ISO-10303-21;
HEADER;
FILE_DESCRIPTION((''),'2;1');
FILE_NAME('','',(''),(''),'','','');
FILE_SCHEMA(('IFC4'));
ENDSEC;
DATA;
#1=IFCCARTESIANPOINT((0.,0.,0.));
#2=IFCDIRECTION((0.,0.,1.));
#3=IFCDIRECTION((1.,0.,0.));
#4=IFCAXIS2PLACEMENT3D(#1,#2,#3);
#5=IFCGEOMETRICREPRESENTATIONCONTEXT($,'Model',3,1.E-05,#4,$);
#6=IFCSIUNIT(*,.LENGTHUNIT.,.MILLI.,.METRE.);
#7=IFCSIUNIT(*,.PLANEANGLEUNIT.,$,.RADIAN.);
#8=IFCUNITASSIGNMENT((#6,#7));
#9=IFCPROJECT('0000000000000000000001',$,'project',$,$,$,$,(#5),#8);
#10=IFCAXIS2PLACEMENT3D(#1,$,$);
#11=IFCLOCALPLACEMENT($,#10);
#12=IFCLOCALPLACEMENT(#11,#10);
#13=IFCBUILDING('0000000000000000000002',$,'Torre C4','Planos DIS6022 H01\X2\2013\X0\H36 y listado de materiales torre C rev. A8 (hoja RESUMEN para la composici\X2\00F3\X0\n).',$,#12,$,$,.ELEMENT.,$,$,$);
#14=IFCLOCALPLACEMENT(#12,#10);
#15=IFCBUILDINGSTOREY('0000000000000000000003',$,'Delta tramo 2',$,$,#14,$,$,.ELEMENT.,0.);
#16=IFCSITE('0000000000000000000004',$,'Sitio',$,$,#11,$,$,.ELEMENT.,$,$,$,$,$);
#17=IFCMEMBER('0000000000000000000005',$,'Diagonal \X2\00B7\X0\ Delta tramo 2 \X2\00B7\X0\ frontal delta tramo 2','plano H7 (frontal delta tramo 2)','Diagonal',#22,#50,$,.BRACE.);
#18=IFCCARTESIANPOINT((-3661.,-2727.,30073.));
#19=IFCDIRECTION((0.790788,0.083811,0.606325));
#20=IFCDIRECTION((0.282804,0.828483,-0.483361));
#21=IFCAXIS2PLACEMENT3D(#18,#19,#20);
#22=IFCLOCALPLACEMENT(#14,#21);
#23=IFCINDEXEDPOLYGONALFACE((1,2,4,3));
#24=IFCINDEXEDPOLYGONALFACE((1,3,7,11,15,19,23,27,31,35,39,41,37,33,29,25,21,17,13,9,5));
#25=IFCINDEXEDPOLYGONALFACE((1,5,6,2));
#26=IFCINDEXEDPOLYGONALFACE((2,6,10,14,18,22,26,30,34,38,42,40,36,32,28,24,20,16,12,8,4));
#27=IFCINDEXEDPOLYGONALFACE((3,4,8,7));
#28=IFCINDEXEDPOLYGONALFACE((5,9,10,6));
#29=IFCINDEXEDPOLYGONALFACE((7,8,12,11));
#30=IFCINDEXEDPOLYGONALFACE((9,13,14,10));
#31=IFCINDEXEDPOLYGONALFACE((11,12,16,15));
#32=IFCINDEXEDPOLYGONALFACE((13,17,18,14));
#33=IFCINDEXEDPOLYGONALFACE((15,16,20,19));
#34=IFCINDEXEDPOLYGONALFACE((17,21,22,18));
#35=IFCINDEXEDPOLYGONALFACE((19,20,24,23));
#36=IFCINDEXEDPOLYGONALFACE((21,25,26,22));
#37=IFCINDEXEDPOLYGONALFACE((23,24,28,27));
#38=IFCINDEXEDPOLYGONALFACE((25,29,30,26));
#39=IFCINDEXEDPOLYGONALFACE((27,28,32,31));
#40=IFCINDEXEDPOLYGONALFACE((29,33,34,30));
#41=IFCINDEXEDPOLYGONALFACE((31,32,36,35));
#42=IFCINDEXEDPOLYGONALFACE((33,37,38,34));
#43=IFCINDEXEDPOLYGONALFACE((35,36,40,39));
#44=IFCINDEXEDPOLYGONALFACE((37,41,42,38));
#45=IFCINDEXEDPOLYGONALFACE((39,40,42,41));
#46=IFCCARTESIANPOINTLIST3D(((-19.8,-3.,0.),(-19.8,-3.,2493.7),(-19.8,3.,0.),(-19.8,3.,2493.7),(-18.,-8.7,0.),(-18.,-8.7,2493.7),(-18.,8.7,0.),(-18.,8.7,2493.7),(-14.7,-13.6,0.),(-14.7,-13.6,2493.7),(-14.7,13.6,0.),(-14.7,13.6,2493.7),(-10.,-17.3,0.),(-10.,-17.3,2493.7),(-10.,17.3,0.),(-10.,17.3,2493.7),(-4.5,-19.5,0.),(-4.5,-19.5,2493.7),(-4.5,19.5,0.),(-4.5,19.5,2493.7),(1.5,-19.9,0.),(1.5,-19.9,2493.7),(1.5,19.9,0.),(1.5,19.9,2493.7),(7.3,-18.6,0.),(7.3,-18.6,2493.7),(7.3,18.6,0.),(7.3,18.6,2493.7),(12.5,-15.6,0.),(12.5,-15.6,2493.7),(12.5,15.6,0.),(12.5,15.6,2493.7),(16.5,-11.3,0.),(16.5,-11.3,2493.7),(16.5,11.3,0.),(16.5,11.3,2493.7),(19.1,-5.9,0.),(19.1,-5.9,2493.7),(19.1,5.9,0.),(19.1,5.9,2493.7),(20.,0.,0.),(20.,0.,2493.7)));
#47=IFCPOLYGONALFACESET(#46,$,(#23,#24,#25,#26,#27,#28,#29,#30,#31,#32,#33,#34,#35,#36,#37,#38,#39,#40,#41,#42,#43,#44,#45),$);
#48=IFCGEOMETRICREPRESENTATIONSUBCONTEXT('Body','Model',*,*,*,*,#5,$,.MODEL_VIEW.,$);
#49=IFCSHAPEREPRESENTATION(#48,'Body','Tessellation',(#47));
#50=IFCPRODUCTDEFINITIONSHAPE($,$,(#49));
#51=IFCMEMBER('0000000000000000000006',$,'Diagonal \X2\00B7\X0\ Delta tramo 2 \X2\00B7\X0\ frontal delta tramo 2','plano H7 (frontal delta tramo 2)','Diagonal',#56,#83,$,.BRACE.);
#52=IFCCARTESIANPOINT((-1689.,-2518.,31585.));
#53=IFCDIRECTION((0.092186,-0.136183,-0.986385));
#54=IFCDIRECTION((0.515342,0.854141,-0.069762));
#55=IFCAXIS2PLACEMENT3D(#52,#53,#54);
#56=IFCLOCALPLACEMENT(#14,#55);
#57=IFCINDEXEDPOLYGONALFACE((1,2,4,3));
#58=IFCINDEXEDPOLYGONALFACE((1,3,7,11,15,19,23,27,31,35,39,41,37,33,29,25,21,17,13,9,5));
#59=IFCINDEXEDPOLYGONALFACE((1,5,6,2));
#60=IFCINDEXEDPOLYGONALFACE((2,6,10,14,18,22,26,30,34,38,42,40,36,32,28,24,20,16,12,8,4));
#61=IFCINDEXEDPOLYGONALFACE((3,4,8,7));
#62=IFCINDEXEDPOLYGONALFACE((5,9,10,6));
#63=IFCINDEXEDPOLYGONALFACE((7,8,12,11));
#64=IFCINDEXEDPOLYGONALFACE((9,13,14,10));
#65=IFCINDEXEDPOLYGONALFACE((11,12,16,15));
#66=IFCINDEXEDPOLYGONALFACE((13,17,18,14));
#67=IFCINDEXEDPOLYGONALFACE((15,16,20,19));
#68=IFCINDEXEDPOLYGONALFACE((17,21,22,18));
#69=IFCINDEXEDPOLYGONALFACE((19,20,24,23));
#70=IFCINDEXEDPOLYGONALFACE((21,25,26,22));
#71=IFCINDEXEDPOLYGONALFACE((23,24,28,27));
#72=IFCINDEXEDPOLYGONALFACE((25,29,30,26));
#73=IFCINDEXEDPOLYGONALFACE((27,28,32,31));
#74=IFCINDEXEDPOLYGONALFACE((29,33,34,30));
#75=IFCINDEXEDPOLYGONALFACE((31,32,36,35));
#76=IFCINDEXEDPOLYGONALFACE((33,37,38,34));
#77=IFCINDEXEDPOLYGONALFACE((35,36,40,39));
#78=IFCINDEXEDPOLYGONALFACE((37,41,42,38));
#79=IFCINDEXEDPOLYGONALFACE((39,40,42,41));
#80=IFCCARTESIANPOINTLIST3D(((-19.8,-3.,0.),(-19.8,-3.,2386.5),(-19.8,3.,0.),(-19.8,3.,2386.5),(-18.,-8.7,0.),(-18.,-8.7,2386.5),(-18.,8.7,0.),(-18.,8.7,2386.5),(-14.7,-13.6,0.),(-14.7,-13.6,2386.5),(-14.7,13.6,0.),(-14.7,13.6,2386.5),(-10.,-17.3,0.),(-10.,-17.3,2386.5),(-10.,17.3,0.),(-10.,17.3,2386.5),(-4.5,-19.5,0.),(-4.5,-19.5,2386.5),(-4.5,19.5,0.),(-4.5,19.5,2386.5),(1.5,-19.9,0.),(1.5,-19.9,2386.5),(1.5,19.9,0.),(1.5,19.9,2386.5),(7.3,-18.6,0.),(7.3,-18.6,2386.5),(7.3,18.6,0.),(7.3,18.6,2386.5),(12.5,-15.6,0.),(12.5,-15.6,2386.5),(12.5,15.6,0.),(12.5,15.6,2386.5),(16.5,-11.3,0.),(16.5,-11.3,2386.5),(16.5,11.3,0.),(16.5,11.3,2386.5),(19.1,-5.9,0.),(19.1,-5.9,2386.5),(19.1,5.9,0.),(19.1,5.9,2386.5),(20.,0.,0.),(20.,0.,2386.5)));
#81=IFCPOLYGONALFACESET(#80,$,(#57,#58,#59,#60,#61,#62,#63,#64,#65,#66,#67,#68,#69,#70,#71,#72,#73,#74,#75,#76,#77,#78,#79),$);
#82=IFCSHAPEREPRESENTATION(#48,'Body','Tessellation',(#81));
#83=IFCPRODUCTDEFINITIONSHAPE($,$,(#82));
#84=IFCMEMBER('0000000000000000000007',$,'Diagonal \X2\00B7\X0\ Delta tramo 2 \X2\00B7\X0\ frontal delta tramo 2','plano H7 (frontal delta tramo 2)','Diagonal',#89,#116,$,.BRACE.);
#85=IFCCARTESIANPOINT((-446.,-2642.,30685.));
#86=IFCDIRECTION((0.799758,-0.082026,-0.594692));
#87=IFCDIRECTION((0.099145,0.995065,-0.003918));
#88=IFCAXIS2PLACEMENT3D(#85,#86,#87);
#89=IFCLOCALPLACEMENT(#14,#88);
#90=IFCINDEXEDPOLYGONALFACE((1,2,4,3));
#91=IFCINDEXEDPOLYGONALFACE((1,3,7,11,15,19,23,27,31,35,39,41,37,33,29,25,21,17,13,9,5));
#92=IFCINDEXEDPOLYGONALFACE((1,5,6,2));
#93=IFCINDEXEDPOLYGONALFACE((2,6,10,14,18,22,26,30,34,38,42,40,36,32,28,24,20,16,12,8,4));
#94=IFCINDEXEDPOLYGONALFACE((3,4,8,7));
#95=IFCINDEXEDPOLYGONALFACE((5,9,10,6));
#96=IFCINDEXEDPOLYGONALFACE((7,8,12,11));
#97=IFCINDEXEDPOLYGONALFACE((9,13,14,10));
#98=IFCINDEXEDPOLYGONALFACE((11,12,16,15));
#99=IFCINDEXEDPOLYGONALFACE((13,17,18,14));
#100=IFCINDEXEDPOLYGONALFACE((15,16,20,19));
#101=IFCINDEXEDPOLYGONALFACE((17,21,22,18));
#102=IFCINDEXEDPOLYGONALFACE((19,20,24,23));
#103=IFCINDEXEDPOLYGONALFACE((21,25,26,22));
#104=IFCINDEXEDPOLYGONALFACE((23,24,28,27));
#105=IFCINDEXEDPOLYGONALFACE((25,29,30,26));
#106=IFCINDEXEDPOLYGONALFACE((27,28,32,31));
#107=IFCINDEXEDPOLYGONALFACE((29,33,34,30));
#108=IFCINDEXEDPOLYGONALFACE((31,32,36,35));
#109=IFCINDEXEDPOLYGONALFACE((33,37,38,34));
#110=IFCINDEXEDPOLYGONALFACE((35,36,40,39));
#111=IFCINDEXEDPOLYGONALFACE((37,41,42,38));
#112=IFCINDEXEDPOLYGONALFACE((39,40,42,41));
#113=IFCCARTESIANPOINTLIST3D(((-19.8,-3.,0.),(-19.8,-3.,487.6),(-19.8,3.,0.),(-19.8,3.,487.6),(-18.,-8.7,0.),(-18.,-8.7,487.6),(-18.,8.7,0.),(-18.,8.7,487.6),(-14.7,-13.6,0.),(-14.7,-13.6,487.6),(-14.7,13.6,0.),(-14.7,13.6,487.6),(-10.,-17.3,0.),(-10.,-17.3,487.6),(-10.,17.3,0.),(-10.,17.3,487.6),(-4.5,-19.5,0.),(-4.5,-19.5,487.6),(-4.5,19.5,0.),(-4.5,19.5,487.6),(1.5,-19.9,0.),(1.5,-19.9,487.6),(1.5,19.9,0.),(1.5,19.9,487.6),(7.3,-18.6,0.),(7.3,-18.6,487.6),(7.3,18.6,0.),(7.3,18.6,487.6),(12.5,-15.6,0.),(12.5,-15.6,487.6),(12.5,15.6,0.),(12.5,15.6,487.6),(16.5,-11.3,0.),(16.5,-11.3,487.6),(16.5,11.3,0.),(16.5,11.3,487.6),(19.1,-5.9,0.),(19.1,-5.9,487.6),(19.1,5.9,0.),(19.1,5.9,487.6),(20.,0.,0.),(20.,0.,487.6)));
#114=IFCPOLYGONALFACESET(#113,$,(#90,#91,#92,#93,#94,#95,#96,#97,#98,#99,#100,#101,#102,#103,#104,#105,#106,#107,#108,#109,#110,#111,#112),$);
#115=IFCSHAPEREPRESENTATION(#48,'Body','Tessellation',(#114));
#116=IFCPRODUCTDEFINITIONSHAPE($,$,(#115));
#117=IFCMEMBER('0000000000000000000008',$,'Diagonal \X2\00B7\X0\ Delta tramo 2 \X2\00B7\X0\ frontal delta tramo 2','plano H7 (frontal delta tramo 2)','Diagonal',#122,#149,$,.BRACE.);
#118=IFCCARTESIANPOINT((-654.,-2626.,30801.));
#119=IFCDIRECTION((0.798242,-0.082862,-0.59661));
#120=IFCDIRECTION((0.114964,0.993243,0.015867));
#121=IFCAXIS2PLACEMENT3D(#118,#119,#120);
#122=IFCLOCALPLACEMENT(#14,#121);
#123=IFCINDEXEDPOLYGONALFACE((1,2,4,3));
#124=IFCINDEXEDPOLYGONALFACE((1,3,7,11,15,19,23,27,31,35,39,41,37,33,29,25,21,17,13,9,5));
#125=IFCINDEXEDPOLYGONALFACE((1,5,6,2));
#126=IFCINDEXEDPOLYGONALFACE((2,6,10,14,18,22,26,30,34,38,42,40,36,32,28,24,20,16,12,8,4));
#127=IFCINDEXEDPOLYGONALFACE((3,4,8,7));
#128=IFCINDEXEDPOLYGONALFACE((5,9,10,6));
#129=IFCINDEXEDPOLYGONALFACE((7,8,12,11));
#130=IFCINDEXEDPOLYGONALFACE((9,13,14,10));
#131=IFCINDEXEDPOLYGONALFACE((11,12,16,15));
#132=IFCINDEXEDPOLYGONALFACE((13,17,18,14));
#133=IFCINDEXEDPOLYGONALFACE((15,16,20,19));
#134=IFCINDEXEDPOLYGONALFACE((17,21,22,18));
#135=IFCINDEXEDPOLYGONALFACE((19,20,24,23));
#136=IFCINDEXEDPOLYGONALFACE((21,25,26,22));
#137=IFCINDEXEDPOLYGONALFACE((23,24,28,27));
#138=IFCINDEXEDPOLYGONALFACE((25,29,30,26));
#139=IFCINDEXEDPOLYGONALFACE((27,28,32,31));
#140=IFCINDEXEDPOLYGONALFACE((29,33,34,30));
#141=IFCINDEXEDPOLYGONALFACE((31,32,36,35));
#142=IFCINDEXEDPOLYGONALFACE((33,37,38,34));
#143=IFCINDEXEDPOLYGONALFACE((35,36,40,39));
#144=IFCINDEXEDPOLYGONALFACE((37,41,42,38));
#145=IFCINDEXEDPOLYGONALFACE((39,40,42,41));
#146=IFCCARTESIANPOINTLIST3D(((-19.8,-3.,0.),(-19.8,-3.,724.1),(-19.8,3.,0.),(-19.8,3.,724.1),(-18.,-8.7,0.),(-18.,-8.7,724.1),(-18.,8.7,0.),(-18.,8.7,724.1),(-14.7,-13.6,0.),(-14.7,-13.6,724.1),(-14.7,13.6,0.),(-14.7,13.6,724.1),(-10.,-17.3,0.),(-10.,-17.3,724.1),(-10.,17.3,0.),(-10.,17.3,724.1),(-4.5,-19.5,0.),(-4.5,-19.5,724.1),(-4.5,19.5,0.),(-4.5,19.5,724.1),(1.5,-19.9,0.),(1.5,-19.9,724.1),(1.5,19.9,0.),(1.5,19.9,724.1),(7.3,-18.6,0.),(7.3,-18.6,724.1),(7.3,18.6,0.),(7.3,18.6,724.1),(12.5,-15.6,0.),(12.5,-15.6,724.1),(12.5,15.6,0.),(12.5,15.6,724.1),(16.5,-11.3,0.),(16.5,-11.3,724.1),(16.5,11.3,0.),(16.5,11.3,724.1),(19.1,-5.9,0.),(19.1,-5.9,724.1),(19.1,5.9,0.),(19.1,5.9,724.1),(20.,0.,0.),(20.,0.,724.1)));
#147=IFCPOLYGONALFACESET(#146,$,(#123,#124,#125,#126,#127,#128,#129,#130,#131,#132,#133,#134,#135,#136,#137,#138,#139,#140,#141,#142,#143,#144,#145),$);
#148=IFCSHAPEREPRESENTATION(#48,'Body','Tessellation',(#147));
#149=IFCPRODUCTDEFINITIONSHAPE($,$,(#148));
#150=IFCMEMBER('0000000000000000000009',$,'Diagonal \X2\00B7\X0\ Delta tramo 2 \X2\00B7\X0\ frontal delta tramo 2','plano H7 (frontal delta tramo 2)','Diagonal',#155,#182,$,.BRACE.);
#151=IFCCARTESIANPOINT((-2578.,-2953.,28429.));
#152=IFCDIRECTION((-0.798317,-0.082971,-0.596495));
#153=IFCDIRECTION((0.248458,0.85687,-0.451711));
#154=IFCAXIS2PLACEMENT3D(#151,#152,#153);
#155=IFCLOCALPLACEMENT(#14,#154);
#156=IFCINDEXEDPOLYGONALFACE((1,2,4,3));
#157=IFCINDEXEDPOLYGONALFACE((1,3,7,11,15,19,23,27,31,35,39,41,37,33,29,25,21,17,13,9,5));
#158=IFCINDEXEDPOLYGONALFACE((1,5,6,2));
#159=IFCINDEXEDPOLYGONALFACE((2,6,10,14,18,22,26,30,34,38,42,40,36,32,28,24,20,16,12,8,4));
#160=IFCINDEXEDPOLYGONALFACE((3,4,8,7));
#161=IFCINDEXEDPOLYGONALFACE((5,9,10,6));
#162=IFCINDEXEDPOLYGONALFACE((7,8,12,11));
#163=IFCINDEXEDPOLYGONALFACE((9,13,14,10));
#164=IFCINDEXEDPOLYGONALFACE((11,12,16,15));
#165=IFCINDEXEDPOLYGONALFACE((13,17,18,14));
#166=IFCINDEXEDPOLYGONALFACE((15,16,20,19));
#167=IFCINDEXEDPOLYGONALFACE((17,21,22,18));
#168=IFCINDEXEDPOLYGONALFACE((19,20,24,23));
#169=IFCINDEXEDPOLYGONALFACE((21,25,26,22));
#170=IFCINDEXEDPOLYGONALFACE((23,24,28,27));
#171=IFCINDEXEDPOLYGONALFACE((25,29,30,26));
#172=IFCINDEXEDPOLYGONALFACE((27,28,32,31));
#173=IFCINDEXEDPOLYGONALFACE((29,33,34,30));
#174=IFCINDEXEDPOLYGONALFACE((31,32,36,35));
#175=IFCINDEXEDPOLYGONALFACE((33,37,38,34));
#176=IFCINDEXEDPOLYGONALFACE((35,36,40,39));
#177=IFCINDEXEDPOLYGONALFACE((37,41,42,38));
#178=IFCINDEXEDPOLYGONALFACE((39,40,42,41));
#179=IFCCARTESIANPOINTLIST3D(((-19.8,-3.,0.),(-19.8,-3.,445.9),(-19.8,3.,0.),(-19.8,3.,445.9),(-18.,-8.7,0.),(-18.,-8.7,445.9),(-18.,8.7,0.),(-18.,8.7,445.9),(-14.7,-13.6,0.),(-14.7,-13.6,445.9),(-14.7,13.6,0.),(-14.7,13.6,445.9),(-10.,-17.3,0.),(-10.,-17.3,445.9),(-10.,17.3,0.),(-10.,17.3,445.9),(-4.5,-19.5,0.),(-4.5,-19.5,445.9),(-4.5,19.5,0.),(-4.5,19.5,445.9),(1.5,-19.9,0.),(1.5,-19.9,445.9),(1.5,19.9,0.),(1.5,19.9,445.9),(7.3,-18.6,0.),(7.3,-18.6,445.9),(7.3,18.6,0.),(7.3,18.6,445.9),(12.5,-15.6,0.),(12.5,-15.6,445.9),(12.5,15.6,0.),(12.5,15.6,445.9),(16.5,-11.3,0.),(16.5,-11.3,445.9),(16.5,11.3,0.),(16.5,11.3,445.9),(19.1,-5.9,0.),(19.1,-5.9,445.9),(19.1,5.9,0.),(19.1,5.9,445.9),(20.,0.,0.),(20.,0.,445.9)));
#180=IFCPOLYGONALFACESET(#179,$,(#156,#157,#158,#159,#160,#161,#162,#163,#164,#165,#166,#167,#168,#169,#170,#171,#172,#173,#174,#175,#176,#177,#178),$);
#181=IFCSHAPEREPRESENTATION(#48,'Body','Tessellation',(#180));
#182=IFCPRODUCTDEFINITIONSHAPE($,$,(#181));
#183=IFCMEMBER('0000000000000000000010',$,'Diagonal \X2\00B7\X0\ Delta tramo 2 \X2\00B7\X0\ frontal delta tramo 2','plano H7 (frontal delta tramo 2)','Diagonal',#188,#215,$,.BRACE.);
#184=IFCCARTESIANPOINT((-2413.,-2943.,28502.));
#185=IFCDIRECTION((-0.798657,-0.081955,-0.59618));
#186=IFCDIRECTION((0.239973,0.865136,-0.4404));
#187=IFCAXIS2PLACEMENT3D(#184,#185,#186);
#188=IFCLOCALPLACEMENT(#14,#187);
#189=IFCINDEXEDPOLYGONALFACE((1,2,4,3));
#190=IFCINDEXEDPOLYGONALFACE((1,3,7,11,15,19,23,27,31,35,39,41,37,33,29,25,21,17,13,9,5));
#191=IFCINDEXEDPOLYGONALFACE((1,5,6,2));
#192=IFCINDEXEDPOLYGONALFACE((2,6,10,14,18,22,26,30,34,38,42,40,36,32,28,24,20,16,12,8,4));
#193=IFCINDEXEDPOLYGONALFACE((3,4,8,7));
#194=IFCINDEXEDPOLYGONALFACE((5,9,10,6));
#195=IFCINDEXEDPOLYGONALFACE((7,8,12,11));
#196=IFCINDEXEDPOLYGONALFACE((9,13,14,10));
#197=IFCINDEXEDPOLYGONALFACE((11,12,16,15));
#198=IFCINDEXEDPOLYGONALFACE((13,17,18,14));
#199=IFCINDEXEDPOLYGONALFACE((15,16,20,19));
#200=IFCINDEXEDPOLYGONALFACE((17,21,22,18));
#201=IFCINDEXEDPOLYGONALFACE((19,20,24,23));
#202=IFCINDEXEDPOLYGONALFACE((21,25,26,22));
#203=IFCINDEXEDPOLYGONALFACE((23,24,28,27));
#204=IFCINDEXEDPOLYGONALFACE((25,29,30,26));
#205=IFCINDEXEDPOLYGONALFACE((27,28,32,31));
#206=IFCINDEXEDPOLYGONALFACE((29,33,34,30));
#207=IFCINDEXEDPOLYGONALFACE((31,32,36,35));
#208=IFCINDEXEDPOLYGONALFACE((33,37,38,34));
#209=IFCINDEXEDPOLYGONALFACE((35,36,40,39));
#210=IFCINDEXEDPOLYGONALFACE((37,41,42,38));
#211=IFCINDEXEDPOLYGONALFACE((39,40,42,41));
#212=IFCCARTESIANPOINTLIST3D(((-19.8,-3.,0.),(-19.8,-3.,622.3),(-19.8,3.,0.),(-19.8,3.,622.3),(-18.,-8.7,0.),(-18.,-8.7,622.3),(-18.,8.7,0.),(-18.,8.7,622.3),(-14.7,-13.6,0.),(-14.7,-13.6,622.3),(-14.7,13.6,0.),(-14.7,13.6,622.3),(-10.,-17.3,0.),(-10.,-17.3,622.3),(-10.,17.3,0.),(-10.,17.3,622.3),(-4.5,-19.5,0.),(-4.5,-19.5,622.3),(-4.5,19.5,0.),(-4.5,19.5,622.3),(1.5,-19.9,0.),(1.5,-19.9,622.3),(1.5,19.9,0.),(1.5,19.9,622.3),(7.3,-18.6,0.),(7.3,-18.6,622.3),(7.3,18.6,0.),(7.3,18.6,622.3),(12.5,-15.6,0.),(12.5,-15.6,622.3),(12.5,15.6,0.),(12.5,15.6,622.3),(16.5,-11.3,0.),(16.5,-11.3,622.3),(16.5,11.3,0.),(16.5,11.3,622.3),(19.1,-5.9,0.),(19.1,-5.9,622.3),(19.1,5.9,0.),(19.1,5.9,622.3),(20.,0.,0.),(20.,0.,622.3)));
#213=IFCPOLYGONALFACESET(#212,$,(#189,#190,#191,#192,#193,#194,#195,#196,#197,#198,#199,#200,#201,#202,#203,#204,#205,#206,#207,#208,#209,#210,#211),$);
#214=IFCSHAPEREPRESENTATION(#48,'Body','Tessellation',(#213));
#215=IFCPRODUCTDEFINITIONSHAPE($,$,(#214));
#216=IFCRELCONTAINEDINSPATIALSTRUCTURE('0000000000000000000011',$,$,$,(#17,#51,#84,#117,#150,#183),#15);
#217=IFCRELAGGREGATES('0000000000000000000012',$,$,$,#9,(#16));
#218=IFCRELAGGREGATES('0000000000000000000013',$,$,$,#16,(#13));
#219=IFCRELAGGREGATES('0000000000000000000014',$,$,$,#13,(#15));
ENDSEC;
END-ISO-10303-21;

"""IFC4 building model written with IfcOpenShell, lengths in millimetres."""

from ifc_helpers import new_model, si_unit, frame, origin, origin_with_axes, place, context, subcontext, project, spatial, circle, extrude, element, save


model = new_model("IFC4")

# Units and contexts
model_context = context("Model", 3, precision=1e-05, world=origin_with_axes())
body_context = subcontext(model_context, "Body", "Model", "MODEL_VIEW")
ifc_project = project(units=[si_unit("LENGTHUNIT", "METRE", prefix="MILLI"), si_unit("PLANEANGLEUNIT", "RADIAN")], contexts=[model_context])

# Site, building, storey
site_placement = place(None, origin())
site = spatial("IfcSite", under=ifc_project, at=site_placement, Name="Sitio", CompositionType="ELEMENT")
building_placement = place(site_placement, origin())
building = spatial("IfcBuilding", under=site, at=building_placement, Name="Torre C4", Description="Planos DIS6022 H01–H36 y listado de materiales torre C rev. A8 (hoja RESUMEN para la composición).", CompositionType="ELEMENT")
storey_placement = place(building_placement, origin())
storey = spatial("IfcBuildingStorey", under=building, at=storey_placement, Name="Delta tramo 2", CompositionType="ELEMENT", Elevation=0.0)

# Members
member_1_placement = place(storey_placement, frame((-3661.0, -2727.0, 30073.0), z_axis=(0.790788, 0.083811, 0.606325), x_axis=(0.282804, 0.828483, -0.483361)))
element("IfcMember", 1, at=member_1_placement, inside=storey, Name="Diagonal · Delta tramo 2 · frontal delta tramo 2", Description="plano H7 (frontal delta tramo 2)", ObjectType="Diagonal", PredefinedType="BRACE", context=body_context, shape_type="SweptSolid", body=[
    extrude(circle(Radius=20.0), None, (0.0, 0.0, 1.0), 2493.7),
])
member_2_placement = place(storey_placement, frame((-1689.0, -2518.0, 31585.0), z_axis=(0.092186, -0.136183, -0.986385), x_axis=(0.515342, 0.854141, -0.069762)))
element("IfcMember", 2, at=member_2_placement, inside=storey, Name="Diagonal · Delta tramo 2 · frontal delta tramo 2", Description="plano H7 (frontal delta tramo 2)", ObjectType="Diagonal", PredefinedType="BRACE", context=body_context, shape_type="SweptSolid", body=[
    extrude(circle(Radius=20.0), None, (0.0, 0.0, 1.0), 2386.5),
])
member_3_placement = place(storey_placement, frame((-446.0, -2642.0, 30685.0), z_axis=(0.799758, -0.082026, -0.594692), x_axis=(0.099145, 0.995065, -0.003918)))
element("IfcMember", 3, at=member_3_placement, inside=storey, Name="Diagonal · Delta tramo 2 · frontal delta tramo 2", Description="plano H7 (frontal delta tramo 2)", ObjectType="Diagonal", PredefinedType="BRACE", context=body_context, shape_type="SweptSolid", body=[
    extrude(circle(Radius=20.0), None, (0.0, 0.0, 1.0), 487.6),
])
member_4_placement = place(storey_placement, frame((-654.0, -2626.0, 30801.0), z_axis=(0.798242, -0.082862, -0.59661), x_axis=(0.114964, 0.993243, 0.015867)))
element("IfcMember", 4, at=member_4_placement, inside=storey, Name="Diagonal · Delta tramo 2 · frontal delta tramo 2", Description="plano H7 (frontal delta tramo 2)", ObjectType="Diagonal", PredefinedType="BRACE", context=body_context, shape_type="SweptSolid", body=[
    extrude(circle(Radius=20.0), None, (0.0, 0.0, 1.0), 724.1),
])
member_5_placement = place(storey_placement, frame((-2578.0, -2953.0, 28429.0), z_axis=(-0.798317, -0.082971, -0.596495), x_axis=(0.248458, 0.85687, -0.451711)))
element("IfcMember", 5, at=member_5_placement, inside=storey, Name="Diagonal · Delta tramo 2 · frontal delta tramo 2", Description="plano H7 (frontal delta tramo 2)", ObjectType="Diagonal", PredefinedType="BRACE", context=body_context, shape_type="SweptSolid", body=[
    extrude(circle(Radius=20.0), None, (0.0, 0.0, 1.0), 445.9),
])
member_6_placement = place(storey_placement, frame((-2413.0, -2943.0, 28502.0), z_axis=(-0.798657, -0.081955, -0.59618), x_axis=(0.239973, 0.865136, -0.4404)))
element("IfcMember", 6, at=member_6_placement, inside=storey, Name="Diagonal · Delta tramo 2 · frontal delta tramo 2", Description="plano H7 (frontal delta tramo 2)", ObjectType="Diagonal", PredefinedType="BRACE", context=body_context, shape_type="SweptSolid", body=[
    extrude(circle(Radius=20.0), None, (0.0, 0.0, 1.0), 622.3),
])

save(model, "model.ifc")
